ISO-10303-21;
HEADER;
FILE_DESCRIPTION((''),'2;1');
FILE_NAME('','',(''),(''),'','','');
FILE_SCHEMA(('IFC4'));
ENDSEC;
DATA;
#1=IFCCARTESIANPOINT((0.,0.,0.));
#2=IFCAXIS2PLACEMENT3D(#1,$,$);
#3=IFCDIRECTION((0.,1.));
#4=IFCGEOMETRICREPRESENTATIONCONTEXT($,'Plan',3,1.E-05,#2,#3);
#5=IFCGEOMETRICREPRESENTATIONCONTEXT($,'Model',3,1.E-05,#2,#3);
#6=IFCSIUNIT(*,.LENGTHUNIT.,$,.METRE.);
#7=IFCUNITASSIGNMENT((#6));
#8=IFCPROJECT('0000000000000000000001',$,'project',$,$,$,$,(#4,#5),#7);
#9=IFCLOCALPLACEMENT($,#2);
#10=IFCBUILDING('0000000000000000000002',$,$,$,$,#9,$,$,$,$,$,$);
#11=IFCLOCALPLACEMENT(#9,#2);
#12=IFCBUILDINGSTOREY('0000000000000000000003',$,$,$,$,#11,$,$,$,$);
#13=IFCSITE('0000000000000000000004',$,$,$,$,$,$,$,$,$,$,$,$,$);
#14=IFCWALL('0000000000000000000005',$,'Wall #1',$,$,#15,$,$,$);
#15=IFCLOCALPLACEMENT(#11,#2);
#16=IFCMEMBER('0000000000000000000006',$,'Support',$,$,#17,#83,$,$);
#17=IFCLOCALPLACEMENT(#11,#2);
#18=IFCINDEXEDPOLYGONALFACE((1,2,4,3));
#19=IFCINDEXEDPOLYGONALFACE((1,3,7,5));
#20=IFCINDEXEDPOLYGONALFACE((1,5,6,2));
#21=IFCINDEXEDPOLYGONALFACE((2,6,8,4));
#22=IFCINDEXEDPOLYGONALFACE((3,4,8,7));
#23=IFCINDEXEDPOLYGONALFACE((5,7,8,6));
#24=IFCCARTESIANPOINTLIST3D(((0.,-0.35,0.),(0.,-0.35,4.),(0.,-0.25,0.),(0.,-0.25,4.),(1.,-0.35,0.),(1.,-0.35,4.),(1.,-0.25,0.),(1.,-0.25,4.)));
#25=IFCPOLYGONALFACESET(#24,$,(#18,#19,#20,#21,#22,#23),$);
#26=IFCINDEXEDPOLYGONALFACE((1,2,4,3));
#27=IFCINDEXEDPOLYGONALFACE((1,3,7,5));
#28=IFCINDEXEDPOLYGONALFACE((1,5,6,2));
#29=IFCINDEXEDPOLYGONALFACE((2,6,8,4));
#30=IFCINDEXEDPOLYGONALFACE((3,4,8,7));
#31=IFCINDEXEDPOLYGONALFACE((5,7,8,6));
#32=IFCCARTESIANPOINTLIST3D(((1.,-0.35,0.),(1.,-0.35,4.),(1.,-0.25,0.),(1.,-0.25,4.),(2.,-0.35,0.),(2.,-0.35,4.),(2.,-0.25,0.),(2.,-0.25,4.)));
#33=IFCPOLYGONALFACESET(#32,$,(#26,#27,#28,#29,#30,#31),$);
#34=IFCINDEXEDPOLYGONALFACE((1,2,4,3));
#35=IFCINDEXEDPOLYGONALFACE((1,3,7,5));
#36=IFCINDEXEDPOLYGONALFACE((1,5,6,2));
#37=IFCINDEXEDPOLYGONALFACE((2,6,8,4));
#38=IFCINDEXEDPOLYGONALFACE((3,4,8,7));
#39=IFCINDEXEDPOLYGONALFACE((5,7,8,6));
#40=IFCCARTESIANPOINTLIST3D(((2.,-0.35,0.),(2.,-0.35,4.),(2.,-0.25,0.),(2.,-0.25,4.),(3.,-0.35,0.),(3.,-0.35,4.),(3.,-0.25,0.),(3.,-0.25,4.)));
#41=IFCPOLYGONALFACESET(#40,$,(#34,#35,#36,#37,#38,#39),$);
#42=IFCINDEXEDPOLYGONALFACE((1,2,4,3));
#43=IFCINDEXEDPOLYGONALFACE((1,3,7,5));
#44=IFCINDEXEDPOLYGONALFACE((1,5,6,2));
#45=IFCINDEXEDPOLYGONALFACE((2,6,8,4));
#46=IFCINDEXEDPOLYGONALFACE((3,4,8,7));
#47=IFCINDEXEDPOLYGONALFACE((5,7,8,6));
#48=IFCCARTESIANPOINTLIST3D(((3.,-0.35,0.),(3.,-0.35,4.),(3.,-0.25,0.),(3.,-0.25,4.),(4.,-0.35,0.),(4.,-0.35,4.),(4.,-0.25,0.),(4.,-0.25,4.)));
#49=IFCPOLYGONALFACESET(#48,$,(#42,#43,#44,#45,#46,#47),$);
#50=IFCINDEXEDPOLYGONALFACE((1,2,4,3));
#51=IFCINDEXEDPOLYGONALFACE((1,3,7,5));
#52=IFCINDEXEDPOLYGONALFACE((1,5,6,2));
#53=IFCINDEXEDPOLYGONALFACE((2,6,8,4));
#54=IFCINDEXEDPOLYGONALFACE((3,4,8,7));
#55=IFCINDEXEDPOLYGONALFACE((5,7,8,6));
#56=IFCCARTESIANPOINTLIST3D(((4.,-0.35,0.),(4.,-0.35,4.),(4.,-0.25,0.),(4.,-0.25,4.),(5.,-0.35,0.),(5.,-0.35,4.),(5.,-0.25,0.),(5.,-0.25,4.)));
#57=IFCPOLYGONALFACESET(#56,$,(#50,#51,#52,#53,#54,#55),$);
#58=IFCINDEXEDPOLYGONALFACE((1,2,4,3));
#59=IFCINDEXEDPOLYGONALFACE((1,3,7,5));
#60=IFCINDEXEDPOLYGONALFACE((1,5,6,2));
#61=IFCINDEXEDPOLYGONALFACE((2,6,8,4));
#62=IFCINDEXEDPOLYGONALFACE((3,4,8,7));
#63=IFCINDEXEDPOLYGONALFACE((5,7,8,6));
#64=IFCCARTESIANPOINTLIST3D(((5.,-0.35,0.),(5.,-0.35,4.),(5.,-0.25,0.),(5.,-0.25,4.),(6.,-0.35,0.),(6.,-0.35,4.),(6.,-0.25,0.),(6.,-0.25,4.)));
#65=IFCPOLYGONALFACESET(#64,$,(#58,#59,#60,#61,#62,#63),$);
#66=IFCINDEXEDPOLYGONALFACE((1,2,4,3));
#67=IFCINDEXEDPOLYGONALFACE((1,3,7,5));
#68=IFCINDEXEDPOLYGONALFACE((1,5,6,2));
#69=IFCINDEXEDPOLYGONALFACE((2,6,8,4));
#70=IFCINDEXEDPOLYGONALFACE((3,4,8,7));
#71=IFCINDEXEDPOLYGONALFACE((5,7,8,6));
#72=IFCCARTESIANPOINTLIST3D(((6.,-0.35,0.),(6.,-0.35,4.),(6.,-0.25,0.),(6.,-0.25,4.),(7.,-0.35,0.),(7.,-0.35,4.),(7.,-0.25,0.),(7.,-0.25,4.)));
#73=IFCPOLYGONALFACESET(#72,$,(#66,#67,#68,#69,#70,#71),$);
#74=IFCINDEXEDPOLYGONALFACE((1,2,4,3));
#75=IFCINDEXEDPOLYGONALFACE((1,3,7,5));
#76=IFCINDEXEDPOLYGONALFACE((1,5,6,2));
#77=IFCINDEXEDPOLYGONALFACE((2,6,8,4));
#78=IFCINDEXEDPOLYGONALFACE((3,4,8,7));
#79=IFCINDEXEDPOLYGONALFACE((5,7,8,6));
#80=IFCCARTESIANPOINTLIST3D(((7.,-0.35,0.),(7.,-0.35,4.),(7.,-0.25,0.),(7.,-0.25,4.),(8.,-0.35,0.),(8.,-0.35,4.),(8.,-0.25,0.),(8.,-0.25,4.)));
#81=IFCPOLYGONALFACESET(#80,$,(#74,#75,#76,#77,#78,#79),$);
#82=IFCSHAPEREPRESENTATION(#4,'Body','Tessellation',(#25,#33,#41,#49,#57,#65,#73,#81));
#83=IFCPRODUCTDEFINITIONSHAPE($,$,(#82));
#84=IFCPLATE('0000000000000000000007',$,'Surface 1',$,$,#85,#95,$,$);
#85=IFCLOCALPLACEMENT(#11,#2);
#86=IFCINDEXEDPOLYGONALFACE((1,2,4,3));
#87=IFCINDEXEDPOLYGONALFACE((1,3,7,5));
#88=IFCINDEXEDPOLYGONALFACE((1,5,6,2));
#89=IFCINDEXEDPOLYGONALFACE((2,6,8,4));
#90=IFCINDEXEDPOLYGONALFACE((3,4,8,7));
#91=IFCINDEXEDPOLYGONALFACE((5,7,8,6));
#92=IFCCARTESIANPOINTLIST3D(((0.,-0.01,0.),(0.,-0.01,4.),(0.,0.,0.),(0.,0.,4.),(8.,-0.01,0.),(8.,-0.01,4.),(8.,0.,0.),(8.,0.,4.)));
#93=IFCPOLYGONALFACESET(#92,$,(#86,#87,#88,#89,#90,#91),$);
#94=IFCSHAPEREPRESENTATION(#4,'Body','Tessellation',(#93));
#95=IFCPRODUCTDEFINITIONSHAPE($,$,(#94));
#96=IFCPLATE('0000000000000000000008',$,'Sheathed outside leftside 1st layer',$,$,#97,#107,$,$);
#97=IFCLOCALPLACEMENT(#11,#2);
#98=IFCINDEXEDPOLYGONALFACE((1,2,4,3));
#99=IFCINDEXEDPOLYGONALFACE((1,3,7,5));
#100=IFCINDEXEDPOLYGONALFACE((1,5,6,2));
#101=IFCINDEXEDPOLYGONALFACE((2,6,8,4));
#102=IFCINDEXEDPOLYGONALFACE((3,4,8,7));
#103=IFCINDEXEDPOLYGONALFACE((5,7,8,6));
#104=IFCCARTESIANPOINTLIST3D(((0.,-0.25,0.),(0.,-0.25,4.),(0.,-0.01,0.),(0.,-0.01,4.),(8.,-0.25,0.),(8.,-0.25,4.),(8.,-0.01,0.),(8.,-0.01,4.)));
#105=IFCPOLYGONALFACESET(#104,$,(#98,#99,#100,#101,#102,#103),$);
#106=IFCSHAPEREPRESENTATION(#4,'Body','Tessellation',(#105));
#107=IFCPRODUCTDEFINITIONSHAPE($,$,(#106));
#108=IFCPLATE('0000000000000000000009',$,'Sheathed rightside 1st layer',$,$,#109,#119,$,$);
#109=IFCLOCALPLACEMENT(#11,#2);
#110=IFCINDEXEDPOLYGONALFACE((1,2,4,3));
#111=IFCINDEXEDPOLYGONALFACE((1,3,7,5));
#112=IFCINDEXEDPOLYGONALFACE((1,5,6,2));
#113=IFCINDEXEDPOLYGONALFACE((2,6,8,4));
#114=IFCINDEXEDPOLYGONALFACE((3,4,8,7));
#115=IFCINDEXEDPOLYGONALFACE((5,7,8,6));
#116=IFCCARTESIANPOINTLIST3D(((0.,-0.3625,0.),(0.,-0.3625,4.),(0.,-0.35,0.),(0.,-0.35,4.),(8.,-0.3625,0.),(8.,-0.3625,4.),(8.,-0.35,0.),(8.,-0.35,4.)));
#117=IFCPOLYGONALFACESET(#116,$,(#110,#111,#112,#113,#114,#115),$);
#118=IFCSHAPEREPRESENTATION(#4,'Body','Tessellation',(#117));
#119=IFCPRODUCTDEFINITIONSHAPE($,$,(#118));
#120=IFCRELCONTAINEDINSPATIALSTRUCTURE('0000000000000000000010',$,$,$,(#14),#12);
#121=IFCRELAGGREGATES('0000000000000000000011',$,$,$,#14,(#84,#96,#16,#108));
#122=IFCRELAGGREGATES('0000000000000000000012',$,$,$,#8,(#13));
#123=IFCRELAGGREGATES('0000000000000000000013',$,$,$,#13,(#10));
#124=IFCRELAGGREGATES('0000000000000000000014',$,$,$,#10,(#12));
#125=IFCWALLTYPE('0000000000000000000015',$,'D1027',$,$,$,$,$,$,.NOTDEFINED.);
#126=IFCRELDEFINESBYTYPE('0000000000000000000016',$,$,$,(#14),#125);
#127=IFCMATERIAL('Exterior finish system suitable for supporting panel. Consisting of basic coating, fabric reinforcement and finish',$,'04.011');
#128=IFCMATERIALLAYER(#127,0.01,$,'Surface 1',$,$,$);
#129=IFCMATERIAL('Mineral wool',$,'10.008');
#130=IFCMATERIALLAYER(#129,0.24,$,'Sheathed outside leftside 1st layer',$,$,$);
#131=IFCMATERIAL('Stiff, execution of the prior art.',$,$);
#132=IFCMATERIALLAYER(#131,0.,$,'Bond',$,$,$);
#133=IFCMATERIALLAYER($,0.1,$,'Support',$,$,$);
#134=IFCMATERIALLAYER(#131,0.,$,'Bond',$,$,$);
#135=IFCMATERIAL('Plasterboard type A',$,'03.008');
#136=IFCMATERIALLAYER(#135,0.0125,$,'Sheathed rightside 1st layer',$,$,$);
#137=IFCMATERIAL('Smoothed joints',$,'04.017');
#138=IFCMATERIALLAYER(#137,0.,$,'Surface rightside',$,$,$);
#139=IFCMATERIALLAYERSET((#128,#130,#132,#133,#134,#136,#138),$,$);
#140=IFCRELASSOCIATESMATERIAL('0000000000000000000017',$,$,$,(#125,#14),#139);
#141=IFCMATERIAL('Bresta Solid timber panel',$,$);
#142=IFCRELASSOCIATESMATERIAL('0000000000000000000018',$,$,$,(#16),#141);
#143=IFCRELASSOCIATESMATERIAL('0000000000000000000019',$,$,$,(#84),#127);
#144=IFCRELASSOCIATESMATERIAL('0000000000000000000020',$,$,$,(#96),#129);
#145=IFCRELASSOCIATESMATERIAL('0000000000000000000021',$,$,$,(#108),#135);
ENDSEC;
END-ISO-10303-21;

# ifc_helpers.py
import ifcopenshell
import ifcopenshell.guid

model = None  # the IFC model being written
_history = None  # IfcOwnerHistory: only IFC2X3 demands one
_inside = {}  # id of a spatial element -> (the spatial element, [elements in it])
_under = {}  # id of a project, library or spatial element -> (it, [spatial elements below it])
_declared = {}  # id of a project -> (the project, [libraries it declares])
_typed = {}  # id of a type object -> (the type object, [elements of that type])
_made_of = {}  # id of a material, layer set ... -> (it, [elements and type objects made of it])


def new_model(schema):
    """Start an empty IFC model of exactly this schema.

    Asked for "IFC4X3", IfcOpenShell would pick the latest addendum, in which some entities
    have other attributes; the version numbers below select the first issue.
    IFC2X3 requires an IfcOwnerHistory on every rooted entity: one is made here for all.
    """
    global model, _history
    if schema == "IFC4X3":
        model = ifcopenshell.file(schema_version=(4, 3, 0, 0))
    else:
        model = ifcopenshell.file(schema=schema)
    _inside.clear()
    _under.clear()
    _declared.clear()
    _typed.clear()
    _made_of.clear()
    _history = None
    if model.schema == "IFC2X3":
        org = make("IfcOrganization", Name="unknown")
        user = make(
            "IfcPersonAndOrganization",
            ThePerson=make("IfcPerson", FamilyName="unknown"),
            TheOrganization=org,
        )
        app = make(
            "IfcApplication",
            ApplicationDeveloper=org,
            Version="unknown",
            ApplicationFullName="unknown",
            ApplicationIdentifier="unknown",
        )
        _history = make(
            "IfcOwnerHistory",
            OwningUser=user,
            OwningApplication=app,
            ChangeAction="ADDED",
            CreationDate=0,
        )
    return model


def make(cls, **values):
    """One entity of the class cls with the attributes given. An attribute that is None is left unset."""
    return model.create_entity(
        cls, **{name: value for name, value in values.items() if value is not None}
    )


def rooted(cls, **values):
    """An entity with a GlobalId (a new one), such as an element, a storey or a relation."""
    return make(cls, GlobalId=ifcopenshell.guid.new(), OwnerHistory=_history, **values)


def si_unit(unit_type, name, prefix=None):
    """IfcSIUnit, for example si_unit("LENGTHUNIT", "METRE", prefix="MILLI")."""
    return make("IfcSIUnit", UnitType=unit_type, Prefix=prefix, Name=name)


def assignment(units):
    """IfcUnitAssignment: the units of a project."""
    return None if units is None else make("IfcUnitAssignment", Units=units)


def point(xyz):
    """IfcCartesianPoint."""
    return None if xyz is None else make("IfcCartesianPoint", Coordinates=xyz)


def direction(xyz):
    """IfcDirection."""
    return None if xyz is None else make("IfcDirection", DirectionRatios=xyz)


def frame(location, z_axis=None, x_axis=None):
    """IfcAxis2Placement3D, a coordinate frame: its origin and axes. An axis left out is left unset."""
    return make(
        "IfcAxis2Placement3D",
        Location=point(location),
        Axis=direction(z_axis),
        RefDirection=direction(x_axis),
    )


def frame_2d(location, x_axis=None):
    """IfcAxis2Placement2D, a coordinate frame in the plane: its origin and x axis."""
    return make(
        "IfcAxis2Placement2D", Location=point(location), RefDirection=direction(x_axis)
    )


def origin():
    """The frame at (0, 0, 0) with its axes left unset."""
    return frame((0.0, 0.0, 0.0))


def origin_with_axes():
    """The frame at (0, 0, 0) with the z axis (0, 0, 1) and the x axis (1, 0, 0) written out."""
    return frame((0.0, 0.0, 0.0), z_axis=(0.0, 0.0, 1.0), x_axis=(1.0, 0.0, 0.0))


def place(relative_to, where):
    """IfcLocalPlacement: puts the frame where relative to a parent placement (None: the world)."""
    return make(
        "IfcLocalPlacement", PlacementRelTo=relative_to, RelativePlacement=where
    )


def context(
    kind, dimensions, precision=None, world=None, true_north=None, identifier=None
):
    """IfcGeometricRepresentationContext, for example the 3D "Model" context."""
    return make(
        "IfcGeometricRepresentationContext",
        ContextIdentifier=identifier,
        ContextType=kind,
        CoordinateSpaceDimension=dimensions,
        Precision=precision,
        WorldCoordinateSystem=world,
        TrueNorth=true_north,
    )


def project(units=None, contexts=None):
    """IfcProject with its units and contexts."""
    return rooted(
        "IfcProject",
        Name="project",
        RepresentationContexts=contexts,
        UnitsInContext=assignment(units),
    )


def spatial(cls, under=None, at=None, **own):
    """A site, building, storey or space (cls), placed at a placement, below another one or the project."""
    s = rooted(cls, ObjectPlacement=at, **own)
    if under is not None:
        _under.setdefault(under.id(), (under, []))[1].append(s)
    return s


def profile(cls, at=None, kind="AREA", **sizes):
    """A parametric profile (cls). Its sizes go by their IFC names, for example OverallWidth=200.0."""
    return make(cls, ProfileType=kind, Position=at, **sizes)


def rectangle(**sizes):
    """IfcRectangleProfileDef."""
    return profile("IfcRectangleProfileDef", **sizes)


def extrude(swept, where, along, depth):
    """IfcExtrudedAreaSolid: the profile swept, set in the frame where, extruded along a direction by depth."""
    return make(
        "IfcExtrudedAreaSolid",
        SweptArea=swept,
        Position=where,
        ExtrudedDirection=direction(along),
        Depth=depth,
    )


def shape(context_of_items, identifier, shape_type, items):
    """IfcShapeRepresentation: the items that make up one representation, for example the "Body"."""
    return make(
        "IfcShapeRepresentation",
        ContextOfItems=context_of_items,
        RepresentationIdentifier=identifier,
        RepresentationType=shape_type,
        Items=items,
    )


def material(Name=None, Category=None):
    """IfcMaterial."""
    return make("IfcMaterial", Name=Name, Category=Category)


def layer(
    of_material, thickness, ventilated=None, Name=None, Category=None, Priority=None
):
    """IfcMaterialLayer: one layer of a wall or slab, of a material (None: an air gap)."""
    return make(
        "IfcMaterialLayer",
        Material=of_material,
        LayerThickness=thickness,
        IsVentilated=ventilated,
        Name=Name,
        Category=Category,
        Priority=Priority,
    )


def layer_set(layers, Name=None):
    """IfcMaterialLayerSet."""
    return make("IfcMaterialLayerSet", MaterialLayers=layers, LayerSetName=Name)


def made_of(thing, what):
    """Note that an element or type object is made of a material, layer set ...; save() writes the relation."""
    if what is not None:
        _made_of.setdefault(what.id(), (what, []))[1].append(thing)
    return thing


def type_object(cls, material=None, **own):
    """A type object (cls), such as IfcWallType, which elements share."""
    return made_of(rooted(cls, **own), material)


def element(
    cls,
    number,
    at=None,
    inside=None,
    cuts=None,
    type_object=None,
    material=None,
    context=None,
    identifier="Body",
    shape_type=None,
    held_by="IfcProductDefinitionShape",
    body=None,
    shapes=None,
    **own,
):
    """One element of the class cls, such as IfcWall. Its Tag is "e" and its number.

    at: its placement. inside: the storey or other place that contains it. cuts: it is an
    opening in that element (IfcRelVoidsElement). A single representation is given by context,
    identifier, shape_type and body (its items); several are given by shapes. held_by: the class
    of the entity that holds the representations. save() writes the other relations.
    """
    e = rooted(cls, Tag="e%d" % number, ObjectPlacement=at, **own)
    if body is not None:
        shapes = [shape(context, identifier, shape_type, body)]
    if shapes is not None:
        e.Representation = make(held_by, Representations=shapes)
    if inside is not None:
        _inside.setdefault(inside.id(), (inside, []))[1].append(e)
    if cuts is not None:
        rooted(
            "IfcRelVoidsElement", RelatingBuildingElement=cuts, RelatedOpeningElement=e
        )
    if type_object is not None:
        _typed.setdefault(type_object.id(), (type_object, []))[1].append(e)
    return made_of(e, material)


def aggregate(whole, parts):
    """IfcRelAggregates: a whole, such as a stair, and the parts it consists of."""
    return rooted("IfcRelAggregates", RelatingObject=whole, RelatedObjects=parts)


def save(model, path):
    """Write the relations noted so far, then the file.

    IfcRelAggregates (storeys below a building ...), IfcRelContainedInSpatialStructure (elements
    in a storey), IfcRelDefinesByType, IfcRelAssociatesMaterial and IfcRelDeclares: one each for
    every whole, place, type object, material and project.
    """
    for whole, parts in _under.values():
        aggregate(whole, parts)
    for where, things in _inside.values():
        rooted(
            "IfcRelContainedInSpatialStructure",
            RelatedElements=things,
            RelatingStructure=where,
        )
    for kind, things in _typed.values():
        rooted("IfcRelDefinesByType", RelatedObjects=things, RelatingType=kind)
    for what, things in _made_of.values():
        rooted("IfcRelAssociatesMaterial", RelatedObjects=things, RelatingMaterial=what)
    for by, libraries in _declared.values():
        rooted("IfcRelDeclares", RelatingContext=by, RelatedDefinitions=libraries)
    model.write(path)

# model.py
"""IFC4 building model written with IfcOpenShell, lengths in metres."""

from ifc_helpers import new_model, si_unit, direction, frame, frame_2d, origin, origin_with_axes, place, context, project, spatial, rectangle, extrude, material, layer, layer_set, type_object, element, aggregate, save


model = new_model("IFC4")

# Units and contexts
plan_context = context("Plan", 3, precision=1e-05, world=origin(), true_north=direction((0.0, 1.0)))
model_context = context("Model", 3, precision=1e-05, world=origin(), true_north=direction((0.0, 1.0)))
ifc_project = project(units=[si_unit("LENGTHUNIT", "METRE")], contexts=[plan_context, model_context])

# Site, building, storey
site = spatial("IfcSite", under=ifc_project)
building_placement = place(None, origin())
building = spatial("IfcBuilding", under=site, at=building_placement)
storey_placement = place(building_placement, origin())
storey = spatial("IfcBuildingStorey", under=building, at=storey_placement)

# Wall, member, plates
ifc_material_1 = material(Name="Exterior finish system suitable for supporting panel. Consisting of basic coating, fabric reinforcement and finish", Category="04.011")
ifc_layer_1 = layer(ifc_material_1, 0.01, Name="Surface 1")
ifc_material_2 = material(Name="Mineral wool", Category="10.008")
ifc_layer_2 = layer(ifc_material_2, 0.24, Name="Sheathed outside leftside 1st layer")
ifc_material_3 = material(Name="Stiff, execution of the prior art.")
ifc_layer_3 = layer(ifc_material_3, 0.0, Name="Bond")
ifc_layer_4 = layer(None, 0.1, Name="Support")
ifc_layer_5 = layer(ifc_material_3, 0.0, Name="Bond")
ifc_material_4 = material(Name="Plasterboard type A", Category="03.008")
ifc_layer_6 = layer(ifc_material_4, 0.0125, Name="Sheathed rightside 1st layer")
ifc_material_5 = material(Name="Smoothed joints", Category="04.017")
ifc_layer_7 = layer(ifc_material_5, 0.0, Name="Surface rightside")
ifc_layer_set = layer_set([ifc_layer_1, ifc_layer_2, ifc_layer_3, ifc_layer_4, ifc_layer_5, ifc_layer_6, ifc_layer_7])
wall_type = type_object("IfcWallType", Name="D1027", PredefinedType="NOTDEFINED", material=ifc_layer_set)
wall_placement = place(None, frame((0.0, 0.0, 0.0), z_axis=(0.0, -1.0, 0.0), x_axis=(1.0, 0.0, 0.0)))
wall = element("IfcWall", 1, at=wall_placement, inside=storey, type_object=wall_type, material=ifc_layer_set, Name="Wall #1")
ifc_material_6 = material(Name="Bresta Solid timber panel")
member_placement = place(wall_placement, origin())
member = element("IfcMember", 2, at=member_placement, material=ifc_material_6, Name="Support", context=plan_context, shape_type="SweptSolid", body=[
    extrude(rectangle(XDim=1.0, YDim=0.1, at=frame_2d((0.5, 0.05), x_axis=(1.0, 0.0))), frame((0.0, 4.0, 0.25), z_axis=(0.0, -1.0, 0.0), x_axis=(1.0, 0.0, 0.0)), (0.0, 0.0, 1.0), 4.0),
    extrude(rectangle(XDim=1.0, YDim=0.1, at=frame_2d((0.5, 0.05), x_axis=(1.0, 0.0))), frame((1.0, 4.0, 0.25), z_axis=(0.0, -1.0, 0.0), x_axis=(1.0, 0.0, 0.0)), (0.0, 0.0, 1.0), 4.0),
    extrude(rectangle(XDim=1.0, YDim=0.1, at=frame_2d((0.5, 0.05), x_axis=(1.0, 0.0))), frame((2.0, 4.0, 0.25), z_axis=(0.0, -1.0, 0.0), x_axis=(1.0, 0.0, 0.0)), (0.0, 0.0, 1.0), 4.0),
    extrude(rectangle(XDim=1.0, YDim=0.1, at=frame_2d((0.5, 0.05), x_axis=(1.0, 0.0))), frame((3.0, 4.0, 0.25), z_axis=(0.0, -1.0, 0.0), x_axis=(1.0, 0.0, 0.0)), (0.0, 0.0, 1.0), 4.0),
    extrude(rectangle(XDim=1.0, YDim=0.1, at=frame_2d((0.5, 0.05), x_axis=(1.0, 0.0))), frame((4.0, 4.0, 0.25), z_axis=(0.0, -1.0, 0.0), x_axis=(1.0, 0.0, 0.0)), (0.0, 0.0, 1.0), 4.0),
    extrude(rectangle(XDim=1.0, YDim=0.1, at=frame_2d((0.5, 0.05), x_axis=(1.0, 0.0))), frame((5.0, 4.0, 0.25), z_axis=(0.0, -1.0, 0.0), x_axis=(1.0, 0.0, 0.0)), (0.0, 0.0, 1.0), 4.0),
    extrude(rectangle(XDim=1.0, YDim=0.1, at=frame_2d((0.5, 0.05), x_axis=(1.0, 0.0))), frame((6.0, 4.0, 0.25), z_axis=(0.0, -1.0, 0.0), x_axis=(1.0, 0.0, 0.0)), (0.0, 0.0, 1.0), 4.0),
    extrude(rectangle(XDim=1.0, YDim=0.1, at=frame_2d((0.5, 0.05), x_axis=(1.0, 0.0))), frame((7.0, 4.0, 0.25), z_axis=(0.0, -1.0, 0.0), x_axis=(1.0, 0.0, 0.0)), (0.0, 0.0, 1.0), 4.0),
])
plate_1_placement = place(wall_placement, origin())
plate_1 = element("IfcPlate", 3, at=plate_1_placement, material=ifc_material_1, Name="Surface 1", context=plan_context, shape_type="SweptSolid", body=[
    extrude(rectangle(XDim=8.0, YDim=4.0, at=frame_2d((4.0, 2.0), x_axis=(1.0, 0.0))), origin_with_axes(), (0.0, 0.0, 1.0), 0.01),
])
plate_2_placement = place(wall_placement, origin())
plate_2 = element("IfcPlate", 4, at=plate_2_placement, material=ifc_material_2, Name="Sheathed outside leftside 1st layer", context=plan_context, shape_type="SweptSolid", body=[
    extrude(rectangle(XDim=8.0, YDim=4.0, at=frame_2d((4.0, 2.0), x_axis=(1.0, 0.0))), frame((0.0, 0.0, 0.01), z_axis=(0.0, 0.0, 1.0), x_axis=(1.0, 0.0, 0.0)), (0.0, 0.0, 1.0), 0.24),
])
plate_3_placement = place(wall_placement, origin())
plate_3 = element("IfcPlate", 5, at=plate_3_placement, material=ifc_material_4, Name="Sheathed rightside 1st layer", context=plan_context, shape_type="SweptSolid", body=[
    extrude(rectangle(XDim=8.0, YDim=4.0, at=frame_2d((4.0, 2.0), x_axis=(1.0, 0.0))), frame((0.0, 0.0, 0.35), z_axis=(0.0, 0.0, 1.0), x_axis=(1.0, 0.0, 0.0)), (0.0, 0.0, 1.0), 0.0125),
])
aggregate(wall, [plate_1, plate_2, member, plate_3])

save(model, "model.ifc")
